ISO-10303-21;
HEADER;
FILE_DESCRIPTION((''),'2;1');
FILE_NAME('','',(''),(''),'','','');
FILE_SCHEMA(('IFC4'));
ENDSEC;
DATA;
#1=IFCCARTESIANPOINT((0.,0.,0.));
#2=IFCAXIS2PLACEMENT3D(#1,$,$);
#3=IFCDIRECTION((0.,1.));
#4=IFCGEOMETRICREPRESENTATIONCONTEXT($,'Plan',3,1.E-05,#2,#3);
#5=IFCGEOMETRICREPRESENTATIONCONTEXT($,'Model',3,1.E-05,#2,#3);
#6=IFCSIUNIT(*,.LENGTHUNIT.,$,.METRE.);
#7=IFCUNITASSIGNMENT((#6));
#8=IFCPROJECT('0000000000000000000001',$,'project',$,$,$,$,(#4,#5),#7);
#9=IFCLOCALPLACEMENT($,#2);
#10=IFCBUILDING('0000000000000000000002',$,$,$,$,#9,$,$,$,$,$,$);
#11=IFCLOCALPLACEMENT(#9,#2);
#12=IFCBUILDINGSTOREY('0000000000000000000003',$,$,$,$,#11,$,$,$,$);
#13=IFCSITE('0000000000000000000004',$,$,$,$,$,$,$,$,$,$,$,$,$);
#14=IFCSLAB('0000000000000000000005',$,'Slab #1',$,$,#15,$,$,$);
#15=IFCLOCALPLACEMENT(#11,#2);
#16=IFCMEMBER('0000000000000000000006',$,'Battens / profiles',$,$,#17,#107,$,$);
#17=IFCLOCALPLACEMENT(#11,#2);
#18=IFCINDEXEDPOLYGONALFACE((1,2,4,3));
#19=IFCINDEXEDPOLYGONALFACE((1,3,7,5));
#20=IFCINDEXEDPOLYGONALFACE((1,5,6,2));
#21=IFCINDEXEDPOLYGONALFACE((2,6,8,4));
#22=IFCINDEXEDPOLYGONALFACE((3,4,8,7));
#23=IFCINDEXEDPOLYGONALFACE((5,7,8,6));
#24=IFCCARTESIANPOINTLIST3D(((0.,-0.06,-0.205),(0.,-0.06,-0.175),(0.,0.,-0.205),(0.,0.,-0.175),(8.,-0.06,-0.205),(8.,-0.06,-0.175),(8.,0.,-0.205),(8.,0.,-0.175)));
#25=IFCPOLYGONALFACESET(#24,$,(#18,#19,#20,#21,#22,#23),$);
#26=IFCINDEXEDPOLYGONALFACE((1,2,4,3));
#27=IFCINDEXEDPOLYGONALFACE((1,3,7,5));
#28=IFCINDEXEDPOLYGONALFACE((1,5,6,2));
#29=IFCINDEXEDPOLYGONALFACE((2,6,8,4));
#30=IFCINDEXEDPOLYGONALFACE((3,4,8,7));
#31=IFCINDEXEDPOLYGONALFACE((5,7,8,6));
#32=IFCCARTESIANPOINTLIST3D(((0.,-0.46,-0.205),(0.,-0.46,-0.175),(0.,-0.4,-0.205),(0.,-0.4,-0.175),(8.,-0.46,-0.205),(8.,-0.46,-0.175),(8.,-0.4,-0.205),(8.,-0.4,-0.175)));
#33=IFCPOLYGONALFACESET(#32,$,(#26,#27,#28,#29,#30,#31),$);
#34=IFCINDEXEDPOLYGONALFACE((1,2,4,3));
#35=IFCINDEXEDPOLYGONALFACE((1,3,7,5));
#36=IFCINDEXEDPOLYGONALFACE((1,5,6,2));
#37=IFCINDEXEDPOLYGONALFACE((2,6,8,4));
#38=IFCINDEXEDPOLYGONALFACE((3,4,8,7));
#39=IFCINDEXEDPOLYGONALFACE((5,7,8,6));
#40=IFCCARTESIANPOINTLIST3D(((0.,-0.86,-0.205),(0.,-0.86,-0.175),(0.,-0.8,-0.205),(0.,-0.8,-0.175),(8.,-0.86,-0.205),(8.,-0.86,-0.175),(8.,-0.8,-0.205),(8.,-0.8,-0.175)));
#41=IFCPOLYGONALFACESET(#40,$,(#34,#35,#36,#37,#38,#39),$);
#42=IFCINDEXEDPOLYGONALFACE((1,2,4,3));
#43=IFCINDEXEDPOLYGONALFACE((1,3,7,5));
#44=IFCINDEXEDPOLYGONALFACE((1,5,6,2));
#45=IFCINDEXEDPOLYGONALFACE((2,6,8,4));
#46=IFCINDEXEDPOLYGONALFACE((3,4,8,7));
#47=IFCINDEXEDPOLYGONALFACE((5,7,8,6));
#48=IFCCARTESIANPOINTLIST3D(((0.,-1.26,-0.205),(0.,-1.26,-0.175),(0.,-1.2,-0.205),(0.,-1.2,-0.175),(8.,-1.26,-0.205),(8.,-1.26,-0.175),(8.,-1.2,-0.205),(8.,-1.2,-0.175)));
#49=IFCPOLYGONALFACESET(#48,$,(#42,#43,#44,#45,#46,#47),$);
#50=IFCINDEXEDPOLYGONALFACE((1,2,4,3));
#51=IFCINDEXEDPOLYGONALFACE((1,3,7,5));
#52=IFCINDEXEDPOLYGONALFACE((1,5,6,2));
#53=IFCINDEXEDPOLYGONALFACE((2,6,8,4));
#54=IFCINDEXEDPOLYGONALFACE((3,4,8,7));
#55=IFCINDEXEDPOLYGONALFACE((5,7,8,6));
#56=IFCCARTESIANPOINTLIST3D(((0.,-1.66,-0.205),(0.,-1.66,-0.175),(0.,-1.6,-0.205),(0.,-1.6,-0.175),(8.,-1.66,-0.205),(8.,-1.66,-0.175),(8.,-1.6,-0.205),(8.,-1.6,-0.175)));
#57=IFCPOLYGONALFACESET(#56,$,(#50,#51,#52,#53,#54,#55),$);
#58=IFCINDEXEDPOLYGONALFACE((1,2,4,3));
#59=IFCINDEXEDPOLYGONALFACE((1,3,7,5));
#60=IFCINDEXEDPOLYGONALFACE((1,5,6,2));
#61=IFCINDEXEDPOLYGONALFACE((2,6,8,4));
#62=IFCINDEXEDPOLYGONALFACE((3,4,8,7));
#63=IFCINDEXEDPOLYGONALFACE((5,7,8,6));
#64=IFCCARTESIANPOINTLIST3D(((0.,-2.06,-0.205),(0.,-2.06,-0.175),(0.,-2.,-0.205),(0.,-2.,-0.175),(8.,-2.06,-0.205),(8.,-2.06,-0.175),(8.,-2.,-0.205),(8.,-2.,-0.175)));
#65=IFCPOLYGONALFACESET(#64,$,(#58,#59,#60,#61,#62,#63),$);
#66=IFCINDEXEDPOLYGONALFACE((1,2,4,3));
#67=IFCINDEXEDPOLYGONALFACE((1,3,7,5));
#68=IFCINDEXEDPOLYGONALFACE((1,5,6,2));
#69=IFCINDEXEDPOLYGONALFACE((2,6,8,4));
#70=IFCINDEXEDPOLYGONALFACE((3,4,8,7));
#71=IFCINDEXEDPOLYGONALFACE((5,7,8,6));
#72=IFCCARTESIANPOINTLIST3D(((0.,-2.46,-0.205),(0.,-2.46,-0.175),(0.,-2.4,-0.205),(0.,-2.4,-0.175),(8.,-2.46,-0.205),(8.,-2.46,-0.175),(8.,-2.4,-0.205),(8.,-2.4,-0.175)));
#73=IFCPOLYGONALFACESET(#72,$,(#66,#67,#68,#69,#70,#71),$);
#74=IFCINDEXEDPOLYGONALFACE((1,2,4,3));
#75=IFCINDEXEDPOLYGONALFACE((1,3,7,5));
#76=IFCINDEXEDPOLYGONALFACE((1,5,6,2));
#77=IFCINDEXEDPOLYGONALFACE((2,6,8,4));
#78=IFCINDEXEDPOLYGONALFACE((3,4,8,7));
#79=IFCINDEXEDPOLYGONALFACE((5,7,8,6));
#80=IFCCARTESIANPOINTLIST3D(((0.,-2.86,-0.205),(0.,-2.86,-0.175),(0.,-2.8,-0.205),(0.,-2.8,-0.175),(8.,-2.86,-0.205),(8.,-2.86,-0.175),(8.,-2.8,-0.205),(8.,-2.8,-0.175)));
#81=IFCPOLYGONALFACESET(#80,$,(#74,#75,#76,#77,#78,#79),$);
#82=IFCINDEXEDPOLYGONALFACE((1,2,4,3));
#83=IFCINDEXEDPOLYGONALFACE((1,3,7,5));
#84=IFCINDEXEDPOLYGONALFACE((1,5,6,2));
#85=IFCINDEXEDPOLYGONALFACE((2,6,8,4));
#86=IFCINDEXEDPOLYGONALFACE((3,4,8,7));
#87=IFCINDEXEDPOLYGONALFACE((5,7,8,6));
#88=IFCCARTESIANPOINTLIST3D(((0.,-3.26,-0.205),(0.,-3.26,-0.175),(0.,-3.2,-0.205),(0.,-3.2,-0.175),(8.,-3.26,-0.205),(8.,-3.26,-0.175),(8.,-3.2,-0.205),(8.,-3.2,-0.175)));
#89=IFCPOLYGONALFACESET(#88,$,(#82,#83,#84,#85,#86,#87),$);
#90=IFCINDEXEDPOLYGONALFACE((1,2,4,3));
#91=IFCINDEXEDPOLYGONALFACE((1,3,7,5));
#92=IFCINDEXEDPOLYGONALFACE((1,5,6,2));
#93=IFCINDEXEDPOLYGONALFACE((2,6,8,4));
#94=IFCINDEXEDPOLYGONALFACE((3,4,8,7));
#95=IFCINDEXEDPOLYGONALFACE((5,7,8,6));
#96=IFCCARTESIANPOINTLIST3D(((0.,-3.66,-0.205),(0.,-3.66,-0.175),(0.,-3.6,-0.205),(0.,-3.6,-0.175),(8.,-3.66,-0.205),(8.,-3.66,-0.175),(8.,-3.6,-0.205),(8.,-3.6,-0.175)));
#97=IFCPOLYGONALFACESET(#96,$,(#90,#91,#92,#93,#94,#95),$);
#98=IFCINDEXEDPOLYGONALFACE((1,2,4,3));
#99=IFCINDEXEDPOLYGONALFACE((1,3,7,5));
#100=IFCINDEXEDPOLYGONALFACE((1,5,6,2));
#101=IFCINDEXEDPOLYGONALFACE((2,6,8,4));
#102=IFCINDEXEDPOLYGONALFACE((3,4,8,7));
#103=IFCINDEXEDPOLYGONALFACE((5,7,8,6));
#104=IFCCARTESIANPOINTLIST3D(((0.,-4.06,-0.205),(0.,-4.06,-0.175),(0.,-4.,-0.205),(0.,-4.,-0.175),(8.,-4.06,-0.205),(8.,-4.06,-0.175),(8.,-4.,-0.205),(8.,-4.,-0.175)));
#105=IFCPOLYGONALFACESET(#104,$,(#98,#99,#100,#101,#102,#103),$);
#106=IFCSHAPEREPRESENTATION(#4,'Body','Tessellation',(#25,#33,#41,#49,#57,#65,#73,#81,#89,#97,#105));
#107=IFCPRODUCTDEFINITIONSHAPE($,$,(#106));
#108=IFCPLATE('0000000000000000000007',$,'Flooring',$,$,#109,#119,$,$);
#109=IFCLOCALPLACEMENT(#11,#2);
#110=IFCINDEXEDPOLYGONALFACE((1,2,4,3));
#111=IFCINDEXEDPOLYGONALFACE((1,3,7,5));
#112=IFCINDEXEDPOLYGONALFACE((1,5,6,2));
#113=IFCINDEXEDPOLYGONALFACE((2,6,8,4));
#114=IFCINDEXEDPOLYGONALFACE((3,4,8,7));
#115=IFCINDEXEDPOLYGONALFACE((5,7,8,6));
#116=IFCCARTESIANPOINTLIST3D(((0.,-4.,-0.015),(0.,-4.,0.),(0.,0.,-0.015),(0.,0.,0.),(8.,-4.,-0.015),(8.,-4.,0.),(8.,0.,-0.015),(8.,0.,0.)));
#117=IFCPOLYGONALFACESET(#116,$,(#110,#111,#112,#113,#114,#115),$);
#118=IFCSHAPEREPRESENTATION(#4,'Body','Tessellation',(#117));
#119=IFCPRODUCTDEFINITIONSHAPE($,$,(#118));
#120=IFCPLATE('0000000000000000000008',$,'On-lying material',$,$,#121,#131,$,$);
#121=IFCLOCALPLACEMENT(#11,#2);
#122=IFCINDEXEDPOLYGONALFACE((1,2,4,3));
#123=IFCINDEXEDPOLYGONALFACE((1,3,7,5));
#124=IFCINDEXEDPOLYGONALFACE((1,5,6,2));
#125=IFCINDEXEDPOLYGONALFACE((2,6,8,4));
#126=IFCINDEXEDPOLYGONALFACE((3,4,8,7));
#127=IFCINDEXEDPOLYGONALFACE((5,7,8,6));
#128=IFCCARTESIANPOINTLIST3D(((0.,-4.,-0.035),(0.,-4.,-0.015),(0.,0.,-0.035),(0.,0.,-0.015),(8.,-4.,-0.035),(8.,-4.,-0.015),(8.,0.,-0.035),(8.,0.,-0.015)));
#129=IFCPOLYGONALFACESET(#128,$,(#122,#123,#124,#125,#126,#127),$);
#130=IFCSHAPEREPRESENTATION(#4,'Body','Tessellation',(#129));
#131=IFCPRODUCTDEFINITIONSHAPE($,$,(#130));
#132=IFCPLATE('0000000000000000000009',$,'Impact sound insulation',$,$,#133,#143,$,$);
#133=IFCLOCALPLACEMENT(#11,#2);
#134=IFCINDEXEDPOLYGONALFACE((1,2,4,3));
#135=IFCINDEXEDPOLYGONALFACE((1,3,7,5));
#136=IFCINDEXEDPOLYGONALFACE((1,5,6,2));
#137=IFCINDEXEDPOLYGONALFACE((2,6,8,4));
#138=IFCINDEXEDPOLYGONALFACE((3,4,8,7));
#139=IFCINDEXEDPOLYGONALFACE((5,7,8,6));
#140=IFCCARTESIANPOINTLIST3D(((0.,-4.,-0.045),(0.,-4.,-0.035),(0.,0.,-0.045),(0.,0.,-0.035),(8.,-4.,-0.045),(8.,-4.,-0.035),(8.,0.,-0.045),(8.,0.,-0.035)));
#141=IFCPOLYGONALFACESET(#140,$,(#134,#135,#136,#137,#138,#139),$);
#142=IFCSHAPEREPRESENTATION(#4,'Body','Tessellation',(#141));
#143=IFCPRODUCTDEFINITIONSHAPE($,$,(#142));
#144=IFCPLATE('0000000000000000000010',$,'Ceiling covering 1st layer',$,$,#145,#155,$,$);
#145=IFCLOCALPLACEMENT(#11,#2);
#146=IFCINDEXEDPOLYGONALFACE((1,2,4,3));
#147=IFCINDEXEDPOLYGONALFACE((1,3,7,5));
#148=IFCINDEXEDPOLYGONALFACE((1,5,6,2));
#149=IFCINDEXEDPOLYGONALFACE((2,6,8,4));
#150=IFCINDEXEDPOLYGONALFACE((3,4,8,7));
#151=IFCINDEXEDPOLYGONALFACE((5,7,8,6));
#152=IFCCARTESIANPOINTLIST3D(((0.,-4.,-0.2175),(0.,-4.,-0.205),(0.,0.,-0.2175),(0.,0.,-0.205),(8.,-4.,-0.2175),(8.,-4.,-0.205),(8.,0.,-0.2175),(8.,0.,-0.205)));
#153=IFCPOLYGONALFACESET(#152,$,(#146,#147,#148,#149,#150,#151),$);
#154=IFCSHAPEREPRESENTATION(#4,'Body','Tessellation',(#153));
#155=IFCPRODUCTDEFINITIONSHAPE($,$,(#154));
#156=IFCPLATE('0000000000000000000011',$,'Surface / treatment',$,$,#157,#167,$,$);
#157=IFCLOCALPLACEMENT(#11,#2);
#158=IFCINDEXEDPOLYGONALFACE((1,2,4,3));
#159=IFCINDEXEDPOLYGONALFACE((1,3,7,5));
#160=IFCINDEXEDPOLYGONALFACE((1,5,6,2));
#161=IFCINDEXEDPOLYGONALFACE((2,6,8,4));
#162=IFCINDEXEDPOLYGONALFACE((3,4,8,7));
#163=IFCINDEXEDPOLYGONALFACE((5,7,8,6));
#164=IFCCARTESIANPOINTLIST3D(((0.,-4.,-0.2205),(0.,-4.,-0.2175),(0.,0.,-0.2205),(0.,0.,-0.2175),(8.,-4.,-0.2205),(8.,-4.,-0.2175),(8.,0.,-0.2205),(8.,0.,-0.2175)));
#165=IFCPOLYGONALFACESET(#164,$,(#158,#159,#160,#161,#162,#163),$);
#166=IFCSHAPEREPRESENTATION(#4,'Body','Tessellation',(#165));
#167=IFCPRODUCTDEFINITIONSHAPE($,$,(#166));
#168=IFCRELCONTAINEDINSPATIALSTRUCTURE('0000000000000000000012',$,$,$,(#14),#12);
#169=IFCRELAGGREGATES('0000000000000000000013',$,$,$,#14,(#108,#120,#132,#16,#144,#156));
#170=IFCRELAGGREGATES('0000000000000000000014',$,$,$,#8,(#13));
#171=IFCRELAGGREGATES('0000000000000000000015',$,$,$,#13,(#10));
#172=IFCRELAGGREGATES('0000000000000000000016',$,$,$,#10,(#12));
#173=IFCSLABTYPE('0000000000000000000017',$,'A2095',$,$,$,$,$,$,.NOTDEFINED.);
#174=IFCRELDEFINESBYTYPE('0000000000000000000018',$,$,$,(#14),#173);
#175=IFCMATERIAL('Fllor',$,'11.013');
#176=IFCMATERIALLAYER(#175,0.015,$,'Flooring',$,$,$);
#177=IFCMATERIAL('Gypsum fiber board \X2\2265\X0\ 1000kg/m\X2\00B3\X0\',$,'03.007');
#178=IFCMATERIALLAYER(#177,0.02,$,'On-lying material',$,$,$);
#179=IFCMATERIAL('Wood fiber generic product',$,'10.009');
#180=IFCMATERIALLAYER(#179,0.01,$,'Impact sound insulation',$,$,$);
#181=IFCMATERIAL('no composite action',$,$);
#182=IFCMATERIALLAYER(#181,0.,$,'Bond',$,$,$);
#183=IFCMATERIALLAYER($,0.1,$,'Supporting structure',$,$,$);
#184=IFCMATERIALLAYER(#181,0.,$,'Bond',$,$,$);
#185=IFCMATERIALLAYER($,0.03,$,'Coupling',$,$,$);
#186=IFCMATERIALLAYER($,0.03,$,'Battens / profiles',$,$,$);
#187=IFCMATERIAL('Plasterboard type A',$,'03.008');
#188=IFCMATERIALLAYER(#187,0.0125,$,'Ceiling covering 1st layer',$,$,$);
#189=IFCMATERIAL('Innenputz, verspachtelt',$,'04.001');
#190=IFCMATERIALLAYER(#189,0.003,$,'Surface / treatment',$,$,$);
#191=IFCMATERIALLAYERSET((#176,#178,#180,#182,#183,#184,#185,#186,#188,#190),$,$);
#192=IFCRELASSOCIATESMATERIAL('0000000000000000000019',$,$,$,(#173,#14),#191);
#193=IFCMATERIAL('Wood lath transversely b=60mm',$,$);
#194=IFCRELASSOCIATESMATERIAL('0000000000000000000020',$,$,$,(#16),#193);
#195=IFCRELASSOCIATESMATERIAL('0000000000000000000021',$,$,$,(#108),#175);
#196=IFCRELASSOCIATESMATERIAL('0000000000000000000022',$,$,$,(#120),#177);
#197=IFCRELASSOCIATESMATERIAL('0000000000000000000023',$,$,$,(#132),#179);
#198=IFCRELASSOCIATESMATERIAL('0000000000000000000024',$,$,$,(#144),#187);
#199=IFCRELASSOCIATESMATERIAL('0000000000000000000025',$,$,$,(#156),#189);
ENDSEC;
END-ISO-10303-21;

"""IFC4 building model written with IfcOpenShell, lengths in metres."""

from ifc_helpers import new_model, si_unit, direction, frame, frame_2d, origin, origin_with_axes, place, context, project, spatial, rectangle, extrude, material, layer, layer_set, type_object, element, aggregate, save


model = new_model("IFC4")

# Units and contexts
plan_context = context("Plan", 3, precision=1e-05, world=origin(), true_north=direction((0.0, 1.0)))
model_context = context("Model", 3, precision=1e-05, world=origin(), true_north=direction((0.0, 1.0)))
ifc_project = project(units=[si_unit("LENGTHUNIT", "METRE")], contexts=[plan_context, model_context])

# Site, building, storey
site = spatial("IfcSite", under=ifc_project)
building_placement = place(None, origin())
building = spatial("IfcBuilding", under=site, at=building_placement)
storey_placement = place(building_placement, origin())
storey = spatial("IfcBuildingStorey", under=building, at=storey_placement)

# Slab, member, plates
ifc_material_1 = material(Name="Fllor", Category="11.013")
ifc_layer_1 = layer(ifc_material_1, 0.015, Name="Flooring")
ifc_material_2 = material(Name="Gypsum fiber board ≥ 1000kg/m³", Category="03.007")
ifc_layer_2 = layer(ifc_material_2, 0.02, Name="On-lying material")
ifc_material_3 = material(Name="Wood fiber generic product", Category="10.009")
ifc_layer_3 = layer(ifc_material_3, 0.01, Name="Impact sound insulation")
ifc_material_4 = material(Name="no composite action")
ifc_layer_4 = layer(ifc_material_4, 0.0, Name="Bond")
ifc_layer_5 = layer(None, 0.1, Name="Supporting structure")
ifc_layer_6 = layer(ifc_material_4, 0.0, Name="Bond")
ifc_layer_7 = layer(None, 0.03, Name="Coupling")
ifc_layer_8 = layer(None, 0.03, Name="Battens / profiles")
ifc_material_5 = material(Name="Plasterboard type A", Category="03.008")
ifc_layer_9 = layer(ifc_material_5, 0.0125, Name="Ceiling covering 1st layer")
ifc_material_6 = material(Name="Innenputz, verspachtelt", Category="04.001")
ifc_layer_10 = layer(ifc_material_6, 0.003, Name="Surface / treatment")
ifc_layer_set = layer_set([ifc_layer_1, ifc_layer_2, ifc_layer_3, ifc_layer_4, ifc_layer_5, ifc_layer_6, ifc_layer_7, ifc_layer_8, ifc_layer_9, ifc_layer_10])
slab_type = type_object("IfcSlabType", Name="A2095", PredefinedType="NOTDEFINED", material=ifc_layer_set)
slab_placement = place(None, frame((0.0, 0.0, 0.0), z_axis=(0.0, 0.0, -1.0), x_axis=(1.0, 0.0, 0.0)))
slab = element("IfcSlab", 1, at=slab_placement, inside=storey, type_object=slab_type, material=ifc_layer_set, Name="Slab #1")
ifc_material_7 = material(Name="Wood lath transversely b=60mm")
member_1_placement = place(slab_placement, origin())
member_1 = element("IfcMember", 2, at=member_1_placement, material=ifc_material_7, Name="Battens / profiles", context=plan_context, shape_type="SweptSolid", body=[
    extrude(rectangle(XDim=0.06, YDim=0.03, at=frame_2d((0.03, 0.015), x_axis=(1.0, 0.0))), frame((0.0, 0.0, 0.175), z_axis=(1.0, 0.0, 0.0), x_axis=(0.0, 1.0, 0.0)), (0.0, 0.0, 1.0), 8.0),
    extrude(rectangle(XDim=0.06, YDim=0.03, at=frame_2d((0.03, 0.015), x_axis=(1.0, 0.0))), frame((0.0, 0.4, 0.175), z_axis=(1.0, 0.0, 0.0), x_axis=(0.0, 1.0, 0.0)), (0.0, 0.0, 1.0), 8.0),
    extrude(rectangle(XDim=0.06, YDim=0.03, at=frame_2d((0.03, 0.015), x_axis=(1.0, 0.0))), frame((0.0, 0.8, 0.175), z_axis=(1.0, 0.0, 0.0), x_axis=(0.0, 1.0, 0.0)), (0.0, 0.0, 1.0), 8.0),
    extrude(rectangle(XDim=0.06, YDim=0.03, at=frame_2d((0.03, 0.015), x_axis=(1.0, 0.0))), frame((0.0, 1.2, 0.175), z_axis=(1.0, 0.0, 0.0), x_axis=(0.0, 1.0, 0.0)), (0.0, 0.0, 1.0), 8.0),
    extrude(rectangle(XDim=0.06, YDim=0.03, at=frame_2d((0.03, 0.015), x_axis=(1.0, 0.0))), frame((0.0, 1.6, 0.175), z_axis=(1.0, 0.0, 0.0), x_axis=(0.0, 1.0, 0.0)), (0.0, 0.0, 1.0), 8.0),
    extrude(rectangle(XDim=0.06, YDim=0.03, at=frame_2d((0.03, 0.015), x_axis=(1.0, 0.0))), frame((0.0, 2.0, 0.175), z_axis=(1.0, 0.0, 0.0), x_axis=(0.0, 1.0, 0.0)), (0.0, 0.0, 1.0), 8.0),
    extrude(rectangle(XDim=0.06, YDim=0.03, at=frame_2d((0.03, 0.015), x_axis=(1.0, 0.0))), frame((0.0, 2.4, 0.175), z_axis=(1.0, 0.0, 0.0), x_axis=(0.0, 1.0, 0.0)), (0.0, 0.0, 1.0), 8.0),
    extrude(rectangle(XDim=0.06, YDim=0.03, at=frame_2d((0.03, 0.015), x_axis=(1.0, 0.0))), frame((0.0, 2.8, 0.175), z_axis=(1.0, 0.0, 0.0), x_axis=(0.0, 1.0, 0.0)), (0.0, 0.0, 1.0), 8.0),
    extrude(rectangle(XDim=0.06, YDim=0.03, at=frame_2d((0.03, 0.015), x_axis=(1.0, 0.0))), frame((0.0, 3.2, 0.175), z_axis=(1.0, 0.0, 0.0), x_axis=(0.0, 1.0, 0.0)), (0.0, 0.0, 1.0), 8.0),
    extrude(rectangle(XDim=0.06, YDim=0.03, at=frame_2d((0.03, 0.015), x_axis=(1.0, 0.0))), frame((0.0, 3.6, 0.175), z_axis=(1.0, 0.0, 0.0), x_axis=(0.0, 1.0, 0.0)), (0.0, 0.0, 1.0), 8.0),
    extrude(rectangle(XDim=0.06, YDim=0.03, at=frame_2d((0.03, 0.015), x_axis=(1.0, 0.0))), frame((0.0, 4.0, 0.175), z_axis=(1.0, 0.0, 0.0), x_axis=(0.0, 1.0, 0.0)), (0.0, 0.0, 1.0), 8.0),
])
plate_1_placement = place(slab_placement, origin())
plate_1 = element("IfcPlate", 3, at=plate_1_placement, material=ifc_material_1, Name="Flooring", context=plan_context, shape_type="SweptSolid", body=[
    extrude(rectangle(XDim=8.0, YDim=4.0, at=frame_2d((4.0, 2.0), x_axis=(1.0, 0.0))), origin_with_axes(), (0.0, 0.0, 1.0), 0.015),
])
plate_2_placement = place(slab_placement, origin())
plate_2 = element("IfcPlate", 4, at=plate_2_placement, material=ifc_material_2, Name="On-lying material", context=plan_context, shape_type="SweptSolid", body=[
    extrude(rectangle(XDim=8.0, YDim=4.0, at=frame_2d((4.0, 2.0), x_axis=(1.0, 0.0))), frame((0.0, 0.0, 0.015), z_axis=(0.0, 0.0, 1.0), x_axis=(1.0, 0.0, 0.0)), (0.0, 0.0, 1.0), 0.02),
])
plate_3_placement = place(slab_placement, origin())
plate_3 = element("IfcPlate", 5, at=plate_3_placement, material=ifc_material_3, Name="Impact sound insulation", context=plan_context, shape_type="SweptSolid", body=[
    extrude(rectangle(XDim=8.0, YDim=4.0, at=frame_2d((4.0, 2.0), x_axis=(1.0, 0.0))), frame((0.0, 0.0, 0.035), z_axis=(0.0, 0.0, 1.0), x_axis=(1.0, 0.0, 0.0)), (0.0, 0.0, 1.0), 0.01),
])
plate_4_placement = place(slab_placement, origin())
plate_4 = element("IfcPlate", 6, at=plate_4_placement, material=ifc_material_5, Name="Ceiling covering 1st layer", context=plan_context, shape_type="SweptSolid", body=[
    extrude(rectangle(XDim=8.0, YDim=4.0, at=frame_2d((4.0, 2.0), x_axis=(1.0, 0.0))), frame((0.0, 0.0, 0.205), z_axis=(0.0, 0.0, 1.0), x_axis=(1.0, 0.0, 0.0)), (0.0, 0.0, 1.0), 0.0125),
])
plate_5_placement = place(slab_placement, origin())
plate_5 = element("IfcPlate", 7, at=plate_5_placement, material=ifc_material_6, Name="Surface / treatment", context=plan_context, shape_type="SweptSolid", body=[
    extrude(rectangle(XDim=8.0, YDim=4.0, at=frame_2d((4.0, 2.0), x_axis=(1.0, 0.0))), frame((0.0, 0.0, 0.2175), z_axis=(0.0, 0.0, 1.0), x_axis=(1.0, 0.0, 0.0)), (0.0, 0.0, 1.0), 0.003),
])
aggregate(slab, [plate_1, plate_2, plate_3, member_1, plate_4, plate_5])

save(model, "model.ifc")
